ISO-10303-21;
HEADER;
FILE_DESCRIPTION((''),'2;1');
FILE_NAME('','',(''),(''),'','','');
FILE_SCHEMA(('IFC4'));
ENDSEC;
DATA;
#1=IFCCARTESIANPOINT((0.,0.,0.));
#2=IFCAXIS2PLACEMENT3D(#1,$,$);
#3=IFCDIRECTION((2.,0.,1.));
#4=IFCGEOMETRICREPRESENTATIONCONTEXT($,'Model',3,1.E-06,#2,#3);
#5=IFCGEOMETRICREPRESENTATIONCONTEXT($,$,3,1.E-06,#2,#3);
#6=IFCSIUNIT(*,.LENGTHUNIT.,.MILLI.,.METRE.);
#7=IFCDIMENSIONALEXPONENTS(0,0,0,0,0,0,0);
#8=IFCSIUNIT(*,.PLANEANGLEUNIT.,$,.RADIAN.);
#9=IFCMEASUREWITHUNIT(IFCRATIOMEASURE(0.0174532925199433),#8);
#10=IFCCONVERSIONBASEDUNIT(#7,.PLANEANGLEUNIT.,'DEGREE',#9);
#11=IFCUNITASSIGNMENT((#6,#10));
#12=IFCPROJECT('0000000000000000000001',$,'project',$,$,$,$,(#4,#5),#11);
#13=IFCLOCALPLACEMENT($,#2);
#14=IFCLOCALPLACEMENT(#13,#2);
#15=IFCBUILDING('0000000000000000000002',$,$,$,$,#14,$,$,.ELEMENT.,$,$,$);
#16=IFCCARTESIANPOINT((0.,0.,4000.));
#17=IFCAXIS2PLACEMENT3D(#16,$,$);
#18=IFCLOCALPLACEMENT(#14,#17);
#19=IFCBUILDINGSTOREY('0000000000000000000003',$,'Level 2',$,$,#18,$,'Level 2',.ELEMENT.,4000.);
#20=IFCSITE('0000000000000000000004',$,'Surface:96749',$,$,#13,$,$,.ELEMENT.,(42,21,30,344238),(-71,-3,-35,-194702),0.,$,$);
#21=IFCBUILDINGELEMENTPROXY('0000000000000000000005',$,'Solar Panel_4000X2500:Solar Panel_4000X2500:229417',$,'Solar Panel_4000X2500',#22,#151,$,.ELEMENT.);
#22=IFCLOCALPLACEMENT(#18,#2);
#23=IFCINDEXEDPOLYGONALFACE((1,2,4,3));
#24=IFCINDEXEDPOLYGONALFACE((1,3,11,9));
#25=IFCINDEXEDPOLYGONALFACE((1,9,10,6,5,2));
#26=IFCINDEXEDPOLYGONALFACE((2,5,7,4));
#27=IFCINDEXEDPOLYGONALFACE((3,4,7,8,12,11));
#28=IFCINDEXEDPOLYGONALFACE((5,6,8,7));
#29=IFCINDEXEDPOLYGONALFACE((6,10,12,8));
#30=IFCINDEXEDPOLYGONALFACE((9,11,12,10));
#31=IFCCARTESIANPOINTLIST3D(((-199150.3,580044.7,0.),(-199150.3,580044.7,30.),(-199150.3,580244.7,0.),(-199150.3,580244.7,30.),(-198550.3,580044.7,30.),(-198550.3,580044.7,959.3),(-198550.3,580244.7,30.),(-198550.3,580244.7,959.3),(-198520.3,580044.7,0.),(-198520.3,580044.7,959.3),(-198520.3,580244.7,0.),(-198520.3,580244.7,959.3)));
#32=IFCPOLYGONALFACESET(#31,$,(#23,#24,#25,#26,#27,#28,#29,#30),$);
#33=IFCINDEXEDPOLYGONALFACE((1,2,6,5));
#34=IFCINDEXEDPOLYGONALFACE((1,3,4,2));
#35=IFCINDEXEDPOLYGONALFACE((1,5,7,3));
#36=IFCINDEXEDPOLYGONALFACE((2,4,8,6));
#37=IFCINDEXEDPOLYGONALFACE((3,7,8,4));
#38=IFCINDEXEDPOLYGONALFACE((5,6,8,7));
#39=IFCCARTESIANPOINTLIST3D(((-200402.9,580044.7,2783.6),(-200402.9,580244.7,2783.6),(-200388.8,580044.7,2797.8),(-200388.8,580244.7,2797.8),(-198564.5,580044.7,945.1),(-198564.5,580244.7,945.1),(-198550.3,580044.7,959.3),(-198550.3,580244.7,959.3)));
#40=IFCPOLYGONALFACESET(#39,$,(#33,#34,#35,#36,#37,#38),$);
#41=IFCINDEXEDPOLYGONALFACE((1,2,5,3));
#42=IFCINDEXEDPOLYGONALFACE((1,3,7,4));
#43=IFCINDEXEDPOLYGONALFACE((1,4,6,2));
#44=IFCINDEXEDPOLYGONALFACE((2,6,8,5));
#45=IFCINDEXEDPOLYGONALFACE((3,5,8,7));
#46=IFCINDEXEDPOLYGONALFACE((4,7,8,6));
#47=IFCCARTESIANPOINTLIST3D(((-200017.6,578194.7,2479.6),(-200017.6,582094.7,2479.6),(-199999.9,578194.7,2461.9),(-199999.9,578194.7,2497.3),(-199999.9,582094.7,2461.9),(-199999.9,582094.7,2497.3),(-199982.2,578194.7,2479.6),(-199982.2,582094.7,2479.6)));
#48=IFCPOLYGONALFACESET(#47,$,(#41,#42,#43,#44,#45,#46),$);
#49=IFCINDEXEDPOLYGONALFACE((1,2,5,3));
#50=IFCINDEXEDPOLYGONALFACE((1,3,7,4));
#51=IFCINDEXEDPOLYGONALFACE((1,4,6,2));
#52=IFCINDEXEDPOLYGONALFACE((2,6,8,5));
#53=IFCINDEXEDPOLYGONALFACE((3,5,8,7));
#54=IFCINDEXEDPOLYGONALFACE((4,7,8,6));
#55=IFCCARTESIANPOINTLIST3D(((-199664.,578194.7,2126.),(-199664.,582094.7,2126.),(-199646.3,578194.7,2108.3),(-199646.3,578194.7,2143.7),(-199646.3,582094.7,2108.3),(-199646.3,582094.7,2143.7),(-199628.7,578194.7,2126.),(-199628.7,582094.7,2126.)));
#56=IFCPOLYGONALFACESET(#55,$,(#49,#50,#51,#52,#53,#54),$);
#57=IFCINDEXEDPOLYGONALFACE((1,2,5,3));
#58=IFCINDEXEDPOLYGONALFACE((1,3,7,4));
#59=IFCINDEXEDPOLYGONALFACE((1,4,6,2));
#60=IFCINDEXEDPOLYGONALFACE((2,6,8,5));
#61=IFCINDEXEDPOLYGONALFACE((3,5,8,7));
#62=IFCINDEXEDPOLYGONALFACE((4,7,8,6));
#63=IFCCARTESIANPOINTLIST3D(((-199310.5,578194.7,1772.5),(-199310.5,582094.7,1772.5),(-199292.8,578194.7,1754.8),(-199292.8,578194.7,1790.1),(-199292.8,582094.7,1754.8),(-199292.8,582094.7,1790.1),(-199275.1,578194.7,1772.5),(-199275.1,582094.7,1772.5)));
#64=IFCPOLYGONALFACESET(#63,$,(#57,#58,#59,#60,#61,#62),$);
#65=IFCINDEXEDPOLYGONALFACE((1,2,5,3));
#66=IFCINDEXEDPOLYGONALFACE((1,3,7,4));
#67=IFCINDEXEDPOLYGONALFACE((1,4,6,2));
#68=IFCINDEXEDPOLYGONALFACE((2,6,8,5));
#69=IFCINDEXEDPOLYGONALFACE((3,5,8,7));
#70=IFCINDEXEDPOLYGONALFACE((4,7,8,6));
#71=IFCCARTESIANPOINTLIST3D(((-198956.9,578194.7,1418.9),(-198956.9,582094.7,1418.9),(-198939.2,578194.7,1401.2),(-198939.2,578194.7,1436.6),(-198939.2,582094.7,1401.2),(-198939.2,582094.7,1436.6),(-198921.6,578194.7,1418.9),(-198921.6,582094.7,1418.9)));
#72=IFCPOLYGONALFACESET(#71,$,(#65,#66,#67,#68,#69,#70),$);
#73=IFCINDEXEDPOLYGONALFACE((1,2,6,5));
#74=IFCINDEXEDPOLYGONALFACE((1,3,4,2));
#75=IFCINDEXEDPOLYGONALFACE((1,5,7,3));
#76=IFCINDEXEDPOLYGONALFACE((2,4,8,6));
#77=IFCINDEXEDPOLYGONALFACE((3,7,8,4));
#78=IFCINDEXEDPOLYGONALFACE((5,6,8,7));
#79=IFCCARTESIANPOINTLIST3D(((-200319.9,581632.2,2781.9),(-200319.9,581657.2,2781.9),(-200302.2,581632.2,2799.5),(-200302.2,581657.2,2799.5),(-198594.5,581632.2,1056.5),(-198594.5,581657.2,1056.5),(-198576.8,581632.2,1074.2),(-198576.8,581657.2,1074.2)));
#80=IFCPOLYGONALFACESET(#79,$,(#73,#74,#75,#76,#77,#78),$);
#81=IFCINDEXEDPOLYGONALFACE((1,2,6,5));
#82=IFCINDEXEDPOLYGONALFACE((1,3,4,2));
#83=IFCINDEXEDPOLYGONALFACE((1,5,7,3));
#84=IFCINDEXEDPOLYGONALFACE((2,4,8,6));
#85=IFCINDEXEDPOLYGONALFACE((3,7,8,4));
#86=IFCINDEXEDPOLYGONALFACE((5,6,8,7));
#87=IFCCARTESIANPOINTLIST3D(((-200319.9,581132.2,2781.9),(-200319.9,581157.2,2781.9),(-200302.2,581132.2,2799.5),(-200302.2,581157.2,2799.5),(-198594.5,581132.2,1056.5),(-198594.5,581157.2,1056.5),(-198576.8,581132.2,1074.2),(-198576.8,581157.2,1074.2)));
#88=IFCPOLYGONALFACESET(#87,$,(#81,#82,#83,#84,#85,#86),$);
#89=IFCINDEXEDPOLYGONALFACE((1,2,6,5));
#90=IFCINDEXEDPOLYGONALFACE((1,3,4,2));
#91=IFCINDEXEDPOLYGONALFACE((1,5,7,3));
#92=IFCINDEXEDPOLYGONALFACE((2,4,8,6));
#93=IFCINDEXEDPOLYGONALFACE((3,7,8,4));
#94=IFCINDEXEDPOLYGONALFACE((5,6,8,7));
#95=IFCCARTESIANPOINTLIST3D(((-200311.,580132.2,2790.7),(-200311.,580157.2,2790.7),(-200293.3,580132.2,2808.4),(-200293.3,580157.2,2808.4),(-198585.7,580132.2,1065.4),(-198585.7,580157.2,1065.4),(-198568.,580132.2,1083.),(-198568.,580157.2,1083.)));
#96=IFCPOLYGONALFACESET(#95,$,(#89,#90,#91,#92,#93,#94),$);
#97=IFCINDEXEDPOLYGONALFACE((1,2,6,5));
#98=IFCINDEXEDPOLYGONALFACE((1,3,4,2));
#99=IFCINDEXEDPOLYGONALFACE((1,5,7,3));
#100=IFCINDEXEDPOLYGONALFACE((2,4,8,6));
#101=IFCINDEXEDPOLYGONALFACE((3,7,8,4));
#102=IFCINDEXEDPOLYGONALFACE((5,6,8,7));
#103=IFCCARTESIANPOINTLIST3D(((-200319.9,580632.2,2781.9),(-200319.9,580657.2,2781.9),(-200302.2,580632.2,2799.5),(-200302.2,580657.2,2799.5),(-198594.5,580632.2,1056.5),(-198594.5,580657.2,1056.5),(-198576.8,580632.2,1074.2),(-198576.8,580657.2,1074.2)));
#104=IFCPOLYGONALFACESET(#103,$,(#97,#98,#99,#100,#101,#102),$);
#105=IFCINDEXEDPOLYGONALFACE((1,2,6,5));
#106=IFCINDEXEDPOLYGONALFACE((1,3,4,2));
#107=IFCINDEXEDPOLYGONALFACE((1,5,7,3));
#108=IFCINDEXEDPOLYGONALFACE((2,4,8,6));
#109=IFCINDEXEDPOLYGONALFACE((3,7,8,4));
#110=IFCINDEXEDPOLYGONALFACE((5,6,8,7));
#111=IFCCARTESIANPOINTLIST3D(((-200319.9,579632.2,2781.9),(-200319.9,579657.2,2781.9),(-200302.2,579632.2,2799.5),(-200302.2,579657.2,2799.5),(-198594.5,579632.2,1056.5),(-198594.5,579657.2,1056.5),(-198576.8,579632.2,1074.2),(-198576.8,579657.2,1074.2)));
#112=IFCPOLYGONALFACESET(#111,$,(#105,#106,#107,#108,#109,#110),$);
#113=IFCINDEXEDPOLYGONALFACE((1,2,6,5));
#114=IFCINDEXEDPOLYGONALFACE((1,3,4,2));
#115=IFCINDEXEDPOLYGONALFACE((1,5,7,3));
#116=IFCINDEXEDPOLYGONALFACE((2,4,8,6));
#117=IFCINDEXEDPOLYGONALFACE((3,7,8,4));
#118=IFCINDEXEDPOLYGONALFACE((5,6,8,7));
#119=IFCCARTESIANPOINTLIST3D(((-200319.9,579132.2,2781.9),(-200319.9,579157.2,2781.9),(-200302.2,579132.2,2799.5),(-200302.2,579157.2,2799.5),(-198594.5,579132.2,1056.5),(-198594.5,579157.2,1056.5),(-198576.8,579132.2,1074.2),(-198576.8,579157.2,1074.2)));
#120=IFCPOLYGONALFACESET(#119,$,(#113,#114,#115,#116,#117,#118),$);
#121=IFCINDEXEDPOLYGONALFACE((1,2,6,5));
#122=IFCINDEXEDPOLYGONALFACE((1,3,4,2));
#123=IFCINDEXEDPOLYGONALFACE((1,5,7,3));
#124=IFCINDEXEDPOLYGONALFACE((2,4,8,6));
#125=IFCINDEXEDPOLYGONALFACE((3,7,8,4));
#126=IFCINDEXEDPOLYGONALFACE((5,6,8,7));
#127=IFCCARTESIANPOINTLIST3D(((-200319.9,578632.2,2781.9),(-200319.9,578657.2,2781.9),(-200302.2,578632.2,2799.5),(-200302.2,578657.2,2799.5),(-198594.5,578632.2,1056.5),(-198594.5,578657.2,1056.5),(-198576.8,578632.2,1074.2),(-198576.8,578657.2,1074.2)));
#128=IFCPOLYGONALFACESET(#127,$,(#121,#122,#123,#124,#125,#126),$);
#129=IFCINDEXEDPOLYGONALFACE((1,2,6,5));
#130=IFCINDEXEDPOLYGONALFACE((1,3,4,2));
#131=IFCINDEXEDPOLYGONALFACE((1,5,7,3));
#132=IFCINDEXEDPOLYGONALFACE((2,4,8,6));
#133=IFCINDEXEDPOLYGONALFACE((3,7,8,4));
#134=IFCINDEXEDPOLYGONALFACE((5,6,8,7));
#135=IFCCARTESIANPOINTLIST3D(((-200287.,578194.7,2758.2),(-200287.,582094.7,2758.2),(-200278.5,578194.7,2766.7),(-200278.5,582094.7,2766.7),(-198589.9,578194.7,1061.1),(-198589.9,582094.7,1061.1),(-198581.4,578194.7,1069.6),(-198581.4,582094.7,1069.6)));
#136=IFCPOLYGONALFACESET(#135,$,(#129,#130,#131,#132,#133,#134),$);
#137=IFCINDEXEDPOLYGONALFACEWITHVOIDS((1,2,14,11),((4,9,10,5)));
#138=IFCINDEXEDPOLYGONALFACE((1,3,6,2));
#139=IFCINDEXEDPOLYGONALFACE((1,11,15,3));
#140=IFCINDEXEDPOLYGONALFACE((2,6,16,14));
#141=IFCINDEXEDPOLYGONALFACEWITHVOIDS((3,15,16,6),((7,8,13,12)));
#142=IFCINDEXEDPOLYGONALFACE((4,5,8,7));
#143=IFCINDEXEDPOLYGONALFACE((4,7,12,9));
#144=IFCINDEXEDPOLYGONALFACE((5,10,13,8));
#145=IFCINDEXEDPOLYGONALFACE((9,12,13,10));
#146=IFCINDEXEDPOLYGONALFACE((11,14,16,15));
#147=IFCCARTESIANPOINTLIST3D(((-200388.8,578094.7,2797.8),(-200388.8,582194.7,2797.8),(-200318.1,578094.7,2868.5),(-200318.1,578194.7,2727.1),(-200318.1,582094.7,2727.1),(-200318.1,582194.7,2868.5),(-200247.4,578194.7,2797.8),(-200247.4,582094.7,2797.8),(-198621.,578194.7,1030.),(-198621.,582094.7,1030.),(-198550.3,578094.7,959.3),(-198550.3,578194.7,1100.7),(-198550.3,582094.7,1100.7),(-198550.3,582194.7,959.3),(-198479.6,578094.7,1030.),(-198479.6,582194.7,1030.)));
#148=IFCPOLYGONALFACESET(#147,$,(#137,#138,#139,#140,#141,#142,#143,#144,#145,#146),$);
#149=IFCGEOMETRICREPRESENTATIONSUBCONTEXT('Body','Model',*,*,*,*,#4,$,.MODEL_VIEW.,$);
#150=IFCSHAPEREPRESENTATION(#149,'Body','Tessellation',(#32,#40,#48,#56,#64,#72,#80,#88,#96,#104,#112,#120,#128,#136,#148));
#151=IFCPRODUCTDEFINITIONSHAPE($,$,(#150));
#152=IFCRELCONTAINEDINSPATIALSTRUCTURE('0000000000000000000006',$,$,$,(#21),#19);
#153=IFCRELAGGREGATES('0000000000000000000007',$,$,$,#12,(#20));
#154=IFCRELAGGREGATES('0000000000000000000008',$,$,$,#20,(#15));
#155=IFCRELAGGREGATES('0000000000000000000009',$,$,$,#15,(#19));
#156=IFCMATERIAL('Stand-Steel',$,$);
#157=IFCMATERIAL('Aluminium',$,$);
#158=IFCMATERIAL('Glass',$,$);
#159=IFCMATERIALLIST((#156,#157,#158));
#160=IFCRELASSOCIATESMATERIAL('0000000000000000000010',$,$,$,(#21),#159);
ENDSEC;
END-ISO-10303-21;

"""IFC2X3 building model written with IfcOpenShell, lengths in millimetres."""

from ifc_helpers import new_model, entity, si_unit, converted_unit, direction, frame, frame_2d, origin, origin_2d_with_axis, place, context, subcontext, project, spatial, polyline, rectangle, outline, extrude, source, transform, mapped, material, material_list, element, save


model = new_model("IFC2X3")

# Units and contexts
model_context = context("Model", 3, precision=1e-06, world=origin(), true_north=direction((2.0, 0.0, 1.0)))
context_of_model = context(None, 3, precision=1e-06, world=origin(), true_north=direction((2.0, 0.0, 1.0)))
body_context = subcontext(model_context, "Body", "Model", "MODEL_VIEW")
ifc_project = project(units=[si_unit("LENGTHUNIT", "METRE", prefix="MILLI"), converted_unit("PLANEANGLEUNIT", "DEGREE", entity("IfcRatioMeasure", 0.0174532925199433), si_unit("PLANEANGLEUNIT", "RADIAN"), dimensions=[0, 0, 0, 0, 0, 0, 0])], contexts=[model_context, context_of_model])

# Site, building, storey
site_placement = place(None, origin())
site = spatial("IfcSite", under=ifc_project, at=site_placement, Name="Surface:96749", CompositionType="ELEMENT", RefLatitude=(42, 21, 30, 344238), RefLongitude=(-71, -3, -35, -194702), RefElevation=0.0)
building_placement = place(site_placement, origin())
building = spatial("IfcBuilding", under=site, at=building_placement, CompositionType="ELEMENT")
storey_placement = place(building_placement, frame((0.0, 0.0, 4000.0)))
storey = spatial("IfcBuildingStorey", under=building, at=storey_placement, Name="Level 2", LongName="Level 2", CompositionType="ELEMENT", Elevation=4000.0)

# Building element proxy
ifc_material_1 = material(Name="Stand-Steel")
ifc_material_2 = material(Name="Aluminium")
ifc_material_3 = material(Name="Glass")
shared_shape = source(origin(), body_context, "Body", "SweptSolid", [
    extrude(outline(polyline([(-629.5, -220.0), (329.8, -220.0), (329.8, 410.0), (299.8, 410.0), (299.8, -190.0), (-629.5, -190.0), (-629.5, -220.0)])), frame((-190.0, -100.0, 299.8), z_axis=(0.0, 1.0, 0.0), x_axis=(0.0, 0.0, -1.0)), (0.0, 0.0, 1.0), 200.0),
    extrude(rectangle(XDim=20.0, YDim=200.0, at=frame_2d((0.0, 0.0), x_axis=(0.0, 1.0))), frame((-7.1, 0.0, 922.2), z_axis=(-0.707107, 0.0, 0.707107), x_axis=(0.0, 1.0, 0.0)), (0.0, 0.0, 1.0), 2600.0),
    extrude(rectangle(XDim=25.0, YDim=25.0, at=frame_2d((0.0, 0.0), x_axis=(1.0, 0.0))), frame((-1449.6, -1950.0, 2449.6), z_axis=(0.0, 1.0, 0.0), x_axis=(-0.707107, 0.0, -0.707107)), (0.0, 0.0, 1.0), 3900.0),
    extrude(rectangle(XDim=25.0, YDim=25.0, at=origin_2d_with_axis()), frame((-1096.0, -1950.0, 2096.0), z_axis=(0.0, 1.0, 0.0), x_axis=(-0.707107, 0.0, -0.707107)), (0.0, 0.0, 1.0), 3900.0),
    extrude(rectangle(XDim=25.0, YDim=25.0, at=origin_2d_with_axis()), frame((-742.5, -1950.0, 1742.5), z_axis=(0.0, 1.0, 0.0), x_axis=(-0.707107, 0.0, -0.707107)), (0.0, 0.0, 1.0), 3900.0),
    extrude(rectangle(XDim=25.0, YDim=25.0, at=frame_2d((0.0, 0.0), x_axis=(1.0, 0.0))), frame((-388.9, -1950.0, 1388.9), z_axis=(0.0, 1.0, 0.0), x_axis=(-0.707107, 0.0, -0.707107)), (0.0, 0.0, 1.0), 3900.0),
    extrude(rectangle(XDim=25.0, YDim=25.0, at=frame_2d((0.0, 0.0), x_axis=(0.0, 1.0))), frame((-35.4, 1500.0, 1035.4), z_axis=(-0.707107, 0.0, 0.707107), x_axis=(0.0, 1.0, 0.0)), (0.0, 0.0, 1.0), 2440.0),
    extrude(rectangle(XDim=25.0, YDim=25.0, at=frame_2d((0.0, 0.0), x_axis=(0.0, 1.0))), frame((-35.4, 1000.0, 1035.4), z_axis=(-0.707107, 0.0, 0.707107), x_axis=(0.0, 1.0, 0.0)), (0.0, 0.0, 1.0), 2440.0),
    extrude(rectangle(XDim=25.0, YDim=25.0, at=frame_2d((0.0, 0.0), x_axis=(0.0, 1.0))), frame((-26.5, 0.0, 1044.2), z_axis=(-0.707107, 0.0, 0.707107), x_axis=(0.0, -1.0, 0.0)), (0.0, 0.0, 1.0), 2440.0),
    extrude(rectangle(XDim=25.0, YDim=25.0, at=frame_2d((0.0, 0.0), x_axis=(0.0, 1.0))), frame((-35.4, 500.0, 1035.4), z_axis=(-0.707107, 0.0, 0.707107), x_axis=(0.0, 1.0, 0.0)), (0.0, 0.0, 1.0), 2440.0),
    extrude(rectangle(XDim=25.0, YDim=25.0, at=frame_2d((0.0, 0.0), x_axis=(0.0, 1.0))), frame((-35.4, -500.0, 1035.4), z_axis=(-0.707107, 0.0, 0.707107), x_axis=(0.0, 1.0, 0.0)), (0.0, 0.0, 1.0), 2440.0),
    extrude(rectangle(XDim=25.0, YDim=25.0, at=frame_2d((0.0, 0.0), x_axis=(0.0, 1.0))), frame((-35.4, -1000.0, 1035.4), z_axis=(-0.707107, 0.0, 0.707107), x_axis=(0.0, 1.0, 0.0)), (0.0, 0.0, 1.0), 2440.0),
    extrude(rectangle(XDim=25.0, YDim=25.0, at=frame_2d((0.0, 0.0), x_axis=(0.0, 1.0))), frame((-35.4, -1500.0, 1035.4), z_axis=(-0.707107, 0.0, 0.707107), x_axis=(0.0, 1.0, 0.0)), (0.0, 0.0, 1.0), 2440.0),
    extrude(rectangle(XDim=2400.0, YDim=12.0, at=frame_2d((0.0, 0.0), x_axis=(1.0, 0.0))), frame((-883.9, -1950.0, 1883.9), z_axis=(0.0, 1.0, 0.0), x_axis=(0.707107, 0.0, -0.707107)), (0.0, 0.0, 1.0), 3900.0),
    extrude(outline(polyline([(-2050.0, -1300.0), (2050.0, -1300.0), (2050.0, 1300.0), (-2050.0, 1300.0), (-2050.0, -1300.0)]), holes=[polyline([(1950.0, -1200.0), (-1950.0, -1200.0), (-1950.0, 1200.0), (1950.0, 1200.0), (1950.0, -1200.0)])]), frame((-919.2, 0.0, 1848.5), z_axis=(0.707107, 0.0, 0.707107), x_axis=(0.0, 1.0, 0.0)), (0.0, 0.0, 1.0), 100.0),
])
ifc_material_list_1 = material_list([ifc_material_1, ifc_material_2, ifc_material_3])
proxy_1_placement = place(storey_placement, frame((-198550.3, 580144.7, 30.0)))
element("IfcBuildingElementProxy", 1, at=proxy_1_placement, inside=storey, material=ifc_material_list_1, Name="Solar Panel_4000X2500:Solar Panel_4000X2500:229417", ObjectType="Solar Panel_4000X2500", CompositionType="ELEMENT", context=body_context, shape_type="MappedRepresentation", body=[
    mapped(shared_shape, transform((0.0, 0.0, 0.0), scale=1.0)),
])

save(model, "model.ifc")
